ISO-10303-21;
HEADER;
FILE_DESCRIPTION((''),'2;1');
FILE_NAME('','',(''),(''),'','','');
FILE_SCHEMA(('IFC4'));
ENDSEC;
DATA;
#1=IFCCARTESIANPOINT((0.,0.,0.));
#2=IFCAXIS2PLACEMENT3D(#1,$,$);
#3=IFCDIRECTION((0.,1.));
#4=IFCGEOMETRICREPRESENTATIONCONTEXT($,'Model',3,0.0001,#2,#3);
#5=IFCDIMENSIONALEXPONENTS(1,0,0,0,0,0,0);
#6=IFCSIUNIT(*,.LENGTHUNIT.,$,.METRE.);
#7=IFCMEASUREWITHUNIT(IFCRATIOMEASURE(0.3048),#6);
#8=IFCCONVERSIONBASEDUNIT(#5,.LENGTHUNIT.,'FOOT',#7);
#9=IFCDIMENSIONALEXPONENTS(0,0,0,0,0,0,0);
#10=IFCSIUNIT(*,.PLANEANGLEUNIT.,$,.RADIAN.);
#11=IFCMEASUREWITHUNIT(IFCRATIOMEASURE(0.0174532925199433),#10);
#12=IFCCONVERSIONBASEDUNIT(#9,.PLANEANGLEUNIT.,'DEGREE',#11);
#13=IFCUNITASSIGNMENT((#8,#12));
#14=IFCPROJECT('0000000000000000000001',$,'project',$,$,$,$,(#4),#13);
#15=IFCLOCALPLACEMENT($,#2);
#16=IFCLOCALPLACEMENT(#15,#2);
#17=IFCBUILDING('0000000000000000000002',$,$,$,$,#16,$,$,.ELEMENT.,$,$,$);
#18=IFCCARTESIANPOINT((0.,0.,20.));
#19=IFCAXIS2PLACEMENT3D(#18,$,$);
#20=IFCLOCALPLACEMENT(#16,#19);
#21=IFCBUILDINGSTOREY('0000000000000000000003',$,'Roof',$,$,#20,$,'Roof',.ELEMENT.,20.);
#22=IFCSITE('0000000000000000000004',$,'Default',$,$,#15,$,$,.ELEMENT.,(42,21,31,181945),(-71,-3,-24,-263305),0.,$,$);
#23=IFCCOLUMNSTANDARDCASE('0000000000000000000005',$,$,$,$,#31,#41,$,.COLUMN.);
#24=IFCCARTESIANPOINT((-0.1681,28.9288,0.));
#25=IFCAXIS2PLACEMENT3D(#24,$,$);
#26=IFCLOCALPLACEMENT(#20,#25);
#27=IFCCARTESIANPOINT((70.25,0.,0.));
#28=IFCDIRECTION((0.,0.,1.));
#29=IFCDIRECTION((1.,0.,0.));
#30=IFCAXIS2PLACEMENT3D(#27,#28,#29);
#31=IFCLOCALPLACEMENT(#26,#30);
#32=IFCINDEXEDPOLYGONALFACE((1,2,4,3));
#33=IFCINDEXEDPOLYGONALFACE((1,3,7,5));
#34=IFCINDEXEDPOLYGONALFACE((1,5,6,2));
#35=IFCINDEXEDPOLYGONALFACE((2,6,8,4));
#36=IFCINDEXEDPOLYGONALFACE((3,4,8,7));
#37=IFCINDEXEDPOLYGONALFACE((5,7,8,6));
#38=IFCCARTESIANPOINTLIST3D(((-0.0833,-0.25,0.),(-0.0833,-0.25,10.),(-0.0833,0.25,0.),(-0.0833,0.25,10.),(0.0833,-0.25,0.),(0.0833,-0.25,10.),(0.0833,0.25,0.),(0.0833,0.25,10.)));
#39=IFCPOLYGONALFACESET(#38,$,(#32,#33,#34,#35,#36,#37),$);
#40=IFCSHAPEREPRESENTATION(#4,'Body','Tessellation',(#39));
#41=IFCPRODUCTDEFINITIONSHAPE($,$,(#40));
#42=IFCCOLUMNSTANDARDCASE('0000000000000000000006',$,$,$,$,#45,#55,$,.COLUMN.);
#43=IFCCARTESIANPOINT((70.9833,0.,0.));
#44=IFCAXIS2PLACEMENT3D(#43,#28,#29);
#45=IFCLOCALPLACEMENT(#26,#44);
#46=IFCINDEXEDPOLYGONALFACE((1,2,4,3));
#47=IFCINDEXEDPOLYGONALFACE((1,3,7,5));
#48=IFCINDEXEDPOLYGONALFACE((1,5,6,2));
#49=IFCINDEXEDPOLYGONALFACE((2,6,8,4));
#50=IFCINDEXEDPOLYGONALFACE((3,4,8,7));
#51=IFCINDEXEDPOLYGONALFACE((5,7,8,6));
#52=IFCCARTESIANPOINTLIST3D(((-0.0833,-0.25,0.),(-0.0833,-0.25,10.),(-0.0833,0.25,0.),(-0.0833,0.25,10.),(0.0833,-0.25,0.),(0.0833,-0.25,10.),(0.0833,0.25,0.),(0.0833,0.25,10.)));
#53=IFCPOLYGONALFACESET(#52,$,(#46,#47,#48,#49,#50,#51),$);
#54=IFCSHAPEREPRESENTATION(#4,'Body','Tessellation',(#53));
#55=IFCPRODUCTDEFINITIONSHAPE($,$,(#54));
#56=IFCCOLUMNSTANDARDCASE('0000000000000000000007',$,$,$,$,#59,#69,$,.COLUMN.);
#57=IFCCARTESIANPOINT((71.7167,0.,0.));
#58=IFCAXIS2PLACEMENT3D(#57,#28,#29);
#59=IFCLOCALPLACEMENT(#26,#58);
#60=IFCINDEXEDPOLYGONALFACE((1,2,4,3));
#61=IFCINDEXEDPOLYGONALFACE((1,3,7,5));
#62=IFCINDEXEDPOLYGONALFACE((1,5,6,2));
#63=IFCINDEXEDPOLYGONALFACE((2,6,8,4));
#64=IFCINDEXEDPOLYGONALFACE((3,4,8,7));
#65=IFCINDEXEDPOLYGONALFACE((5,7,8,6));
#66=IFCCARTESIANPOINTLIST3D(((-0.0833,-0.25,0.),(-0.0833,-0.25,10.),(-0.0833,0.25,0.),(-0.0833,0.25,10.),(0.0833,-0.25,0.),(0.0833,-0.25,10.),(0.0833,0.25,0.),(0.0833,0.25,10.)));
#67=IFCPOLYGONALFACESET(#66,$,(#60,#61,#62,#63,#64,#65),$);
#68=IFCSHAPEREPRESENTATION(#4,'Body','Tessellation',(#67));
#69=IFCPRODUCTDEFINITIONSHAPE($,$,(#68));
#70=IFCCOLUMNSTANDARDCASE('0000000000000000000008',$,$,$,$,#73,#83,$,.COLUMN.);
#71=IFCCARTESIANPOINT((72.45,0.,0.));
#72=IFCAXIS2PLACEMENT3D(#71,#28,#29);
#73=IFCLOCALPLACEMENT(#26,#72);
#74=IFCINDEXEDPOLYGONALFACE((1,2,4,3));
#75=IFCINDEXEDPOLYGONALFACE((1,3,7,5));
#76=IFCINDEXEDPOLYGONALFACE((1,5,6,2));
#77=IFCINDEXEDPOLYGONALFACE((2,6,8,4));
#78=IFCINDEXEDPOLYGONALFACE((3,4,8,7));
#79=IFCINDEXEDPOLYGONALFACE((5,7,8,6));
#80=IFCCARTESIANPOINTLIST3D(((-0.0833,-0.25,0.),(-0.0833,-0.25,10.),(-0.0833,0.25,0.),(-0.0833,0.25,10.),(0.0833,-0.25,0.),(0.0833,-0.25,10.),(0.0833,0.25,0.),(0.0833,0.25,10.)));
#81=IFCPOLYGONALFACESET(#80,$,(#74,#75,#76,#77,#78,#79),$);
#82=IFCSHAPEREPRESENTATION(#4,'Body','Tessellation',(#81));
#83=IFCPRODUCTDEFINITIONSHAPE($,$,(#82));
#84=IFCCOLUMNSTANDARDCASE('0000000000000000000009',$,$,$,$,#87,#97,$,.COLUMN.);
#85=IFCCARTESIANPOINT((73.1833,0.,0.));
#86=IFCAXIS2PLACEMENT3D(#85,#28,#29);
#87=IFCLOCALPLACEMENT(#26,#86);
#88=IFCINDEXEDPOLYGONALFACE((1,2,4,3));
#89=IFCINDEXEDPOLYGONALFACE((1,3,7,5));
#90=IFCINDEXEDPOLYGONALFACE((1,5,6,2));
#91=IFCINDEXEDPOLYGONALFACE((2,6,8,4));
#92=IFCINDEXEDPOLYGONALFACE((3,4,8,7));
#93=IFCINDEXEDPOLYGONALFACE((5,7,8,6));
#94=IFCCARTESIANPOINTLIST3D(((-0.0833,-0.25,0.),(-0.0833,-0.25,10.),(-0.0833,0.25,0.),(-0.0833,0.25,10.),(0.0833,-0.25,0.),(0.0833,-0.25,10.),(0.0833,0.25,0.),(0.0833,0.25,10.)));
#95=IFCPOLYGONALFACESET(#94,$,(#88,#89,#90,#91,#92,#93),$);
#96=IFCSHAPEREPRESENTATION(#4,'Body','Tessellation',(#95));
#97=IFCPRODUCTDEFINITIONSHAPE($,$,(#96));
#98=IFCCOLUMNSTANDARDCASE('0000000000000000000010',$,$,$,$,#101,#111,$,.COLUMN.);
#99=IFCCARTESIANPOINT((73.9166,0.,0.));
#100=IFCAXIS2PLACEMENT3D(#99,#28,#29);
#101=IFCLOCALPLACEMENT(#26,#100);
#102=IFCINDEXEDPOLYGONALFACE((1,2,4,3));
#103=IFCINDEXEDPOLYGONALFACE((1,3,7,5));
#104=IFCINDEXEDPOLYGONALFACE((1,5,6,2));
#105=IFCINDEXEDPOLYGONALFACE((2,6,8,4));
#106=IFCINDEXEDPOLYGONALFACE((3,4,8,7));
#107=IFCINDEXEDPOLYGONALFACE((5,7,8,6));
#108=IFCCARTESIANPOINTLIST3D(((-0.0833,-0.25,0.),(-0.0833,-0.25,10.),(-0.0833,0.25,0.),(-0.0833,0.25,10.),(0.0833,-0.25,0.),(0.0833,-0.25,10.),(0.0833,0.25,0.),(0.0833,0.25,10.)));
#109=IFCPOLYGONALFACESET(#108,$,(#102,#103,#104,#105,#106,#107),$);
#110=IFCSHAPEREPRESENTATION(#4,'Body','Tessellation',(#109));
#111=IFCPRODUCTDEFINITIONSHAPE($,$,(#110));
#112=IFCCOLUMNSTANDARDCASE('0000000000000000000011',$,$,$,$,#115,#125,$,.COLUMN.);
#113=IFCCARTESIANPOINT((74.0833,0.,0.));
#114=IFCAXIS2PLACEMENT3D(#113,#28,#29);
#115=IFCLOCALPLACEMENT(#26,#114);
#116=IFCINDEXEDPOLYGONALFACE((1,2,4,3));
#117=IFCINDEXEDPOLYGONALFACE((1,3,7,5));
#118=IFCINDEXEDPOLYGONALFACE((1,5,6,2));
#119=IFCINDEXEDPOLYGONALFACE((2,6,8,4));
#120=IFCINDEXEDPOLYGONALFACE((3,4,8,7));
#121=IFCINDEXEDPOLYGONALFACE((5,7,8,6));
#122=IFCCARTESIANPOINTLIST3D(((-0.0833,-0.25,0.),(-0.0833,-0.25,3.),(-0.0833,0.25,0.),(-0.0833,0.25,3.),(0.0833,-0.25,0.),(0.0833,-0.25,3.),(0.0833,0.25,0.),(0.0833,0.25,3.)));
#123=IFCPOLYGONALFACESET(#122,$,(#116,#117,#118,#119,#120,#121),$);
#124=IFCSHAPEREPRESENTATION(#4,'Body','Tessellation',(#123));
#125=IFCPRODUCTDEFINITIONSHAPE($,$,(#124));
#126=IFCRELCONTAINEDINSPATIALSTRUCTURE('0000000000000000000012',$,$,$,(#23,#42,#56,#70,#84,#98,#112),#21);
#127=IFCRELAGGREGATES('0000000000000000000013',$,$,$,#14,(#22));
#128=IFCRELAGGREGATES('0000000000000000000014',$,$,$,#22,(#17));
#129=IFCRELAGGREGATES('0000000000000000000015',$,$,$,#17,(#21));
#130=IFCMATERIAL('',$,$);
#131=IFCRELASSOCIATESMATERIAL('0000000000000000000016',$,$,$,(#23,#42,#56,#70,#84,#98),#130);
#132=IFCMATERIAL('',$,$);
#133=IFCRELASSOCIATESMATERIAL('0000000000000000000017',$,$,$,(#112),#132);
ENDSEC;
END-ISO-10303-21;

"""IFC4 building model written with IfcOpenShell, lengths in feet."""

from ifc_helpers import new_model, entity, si_unit, converted_unit, direction, frame, origin, place, context, project, spatial, rectangle, extrude, material, element, save


model = new_model("IFC4")

# Units and contexts
model_context = context("Model", 3, precision=0.0001, world=origin(), true_north=direction((0.0, 1.0)))
ifc_project = project(units=[converted_unit("LENGTHUNIT", "FOOT", entity("IfcRatioMeasure", 0.3048), si_unit("LENGTHUNIT", "METRE"), dimensions=[1, 0, 0, 0, 0, 0, 0]), converted_unit("PLANEANGLEUNIT", "DEGREE", entity("IfcRatioMeasure", 0.0174532925199433), si_unit("PLANEANGLEUNIT", "RADIAN"), dimensions=[0, 0, 0, 0, 0, 0, 0])], contexts=[model_context])

# Site, building, storey
site_placement = place(None, origin())
site = spatial("IfcSite", under=ifc_project, at=site_placement, Name="Default", CompositionType="ELEMENT", RefLatitude=(42, 21, 31, 181945), RefLongitude=(-71, -3, -24, -263305), RefElevation=0.0)
building_placement = place(site_placement, origin())
building = spatial("IfcBuilding", under=site, at=building_placement, CompositionType="ELEMENT")
storey_placement = place(building_placement, frame((0.0, 0.0, 20.0)))
storey = spatial("IfcBuildingStorey", under=building, at=storey_placement, Name="Roof", LongName="Roof", CompositionType="ELEMENT", Elevation=20.0)

# Columns
ifc_material_1 = material(Name="")
placement = place(storey_placement, frame((-0.1681, 28.9288, 0.0)))
for number, where, z_axis, x_axis in (
    (1, (70.25, 0.0, 0.0), (0.0, 0.0, 1.0), (1.0, 0.0, 0.0)),
    (2, (70.9833, 0.0, 0.0), (0.0, 0.0, 1.0), (1.0, 0.0, 0.0)),
    (3, (71.7167, 0.0, 0.0), (0.0, 0.0, 1.0), (1.0, 0.0, 0.0)),
    (4, (72.45, 0.0, 0.0), (0.0, 0.0, 1.0), (1.0, 0.0, 0.0)),
    (5, (73.1833, 0.0, 0.0), (0.0, 0.0, 1.0), (1.0, 0.0, 0.0)),
    (6, (73.9166, 0.0, 0.0), (0.0, 0.0, 1.0), (1.0, 0.0, 0.0)),
):
    element("IfcColumnStandardCase", number, at=place(placement, frame(where, z_axis=z_axis, x_axis=x_axis)), inside=storey, material=ifc_material_1, PredefinedType="COLUMN", context=model_context, shape_type="SweptSolid", body=[
        extrude(rectangle(XDim=0.1667, YDim=0.5), origin(), (0.0, 0.0, 1.0), 10.0),
    ])
ifc_material_2 = material(Name="")
for number, where, z_axis, x_axis in (
    (7, (74.0833, 0.0, 0.0), (0.0, 0.0, 1.0), (1.0, 0.0, 0.0)),
):
    element("IfcColumnStandardCase", number, at=place(placement, frame(where, z_axis=z_axis, x_axis=x_axis)), inside=storey, material=ifc_material_2, PredefinedType="COLUMN", context=model_context, shape_type="SweptSolid", body=[
        extrude(rectangle(XDim=0.1667, YDim=0.5), origin(), (0.0, 0.0, 1.0), 3.0),
    ])

save(model, "model.ifc")
